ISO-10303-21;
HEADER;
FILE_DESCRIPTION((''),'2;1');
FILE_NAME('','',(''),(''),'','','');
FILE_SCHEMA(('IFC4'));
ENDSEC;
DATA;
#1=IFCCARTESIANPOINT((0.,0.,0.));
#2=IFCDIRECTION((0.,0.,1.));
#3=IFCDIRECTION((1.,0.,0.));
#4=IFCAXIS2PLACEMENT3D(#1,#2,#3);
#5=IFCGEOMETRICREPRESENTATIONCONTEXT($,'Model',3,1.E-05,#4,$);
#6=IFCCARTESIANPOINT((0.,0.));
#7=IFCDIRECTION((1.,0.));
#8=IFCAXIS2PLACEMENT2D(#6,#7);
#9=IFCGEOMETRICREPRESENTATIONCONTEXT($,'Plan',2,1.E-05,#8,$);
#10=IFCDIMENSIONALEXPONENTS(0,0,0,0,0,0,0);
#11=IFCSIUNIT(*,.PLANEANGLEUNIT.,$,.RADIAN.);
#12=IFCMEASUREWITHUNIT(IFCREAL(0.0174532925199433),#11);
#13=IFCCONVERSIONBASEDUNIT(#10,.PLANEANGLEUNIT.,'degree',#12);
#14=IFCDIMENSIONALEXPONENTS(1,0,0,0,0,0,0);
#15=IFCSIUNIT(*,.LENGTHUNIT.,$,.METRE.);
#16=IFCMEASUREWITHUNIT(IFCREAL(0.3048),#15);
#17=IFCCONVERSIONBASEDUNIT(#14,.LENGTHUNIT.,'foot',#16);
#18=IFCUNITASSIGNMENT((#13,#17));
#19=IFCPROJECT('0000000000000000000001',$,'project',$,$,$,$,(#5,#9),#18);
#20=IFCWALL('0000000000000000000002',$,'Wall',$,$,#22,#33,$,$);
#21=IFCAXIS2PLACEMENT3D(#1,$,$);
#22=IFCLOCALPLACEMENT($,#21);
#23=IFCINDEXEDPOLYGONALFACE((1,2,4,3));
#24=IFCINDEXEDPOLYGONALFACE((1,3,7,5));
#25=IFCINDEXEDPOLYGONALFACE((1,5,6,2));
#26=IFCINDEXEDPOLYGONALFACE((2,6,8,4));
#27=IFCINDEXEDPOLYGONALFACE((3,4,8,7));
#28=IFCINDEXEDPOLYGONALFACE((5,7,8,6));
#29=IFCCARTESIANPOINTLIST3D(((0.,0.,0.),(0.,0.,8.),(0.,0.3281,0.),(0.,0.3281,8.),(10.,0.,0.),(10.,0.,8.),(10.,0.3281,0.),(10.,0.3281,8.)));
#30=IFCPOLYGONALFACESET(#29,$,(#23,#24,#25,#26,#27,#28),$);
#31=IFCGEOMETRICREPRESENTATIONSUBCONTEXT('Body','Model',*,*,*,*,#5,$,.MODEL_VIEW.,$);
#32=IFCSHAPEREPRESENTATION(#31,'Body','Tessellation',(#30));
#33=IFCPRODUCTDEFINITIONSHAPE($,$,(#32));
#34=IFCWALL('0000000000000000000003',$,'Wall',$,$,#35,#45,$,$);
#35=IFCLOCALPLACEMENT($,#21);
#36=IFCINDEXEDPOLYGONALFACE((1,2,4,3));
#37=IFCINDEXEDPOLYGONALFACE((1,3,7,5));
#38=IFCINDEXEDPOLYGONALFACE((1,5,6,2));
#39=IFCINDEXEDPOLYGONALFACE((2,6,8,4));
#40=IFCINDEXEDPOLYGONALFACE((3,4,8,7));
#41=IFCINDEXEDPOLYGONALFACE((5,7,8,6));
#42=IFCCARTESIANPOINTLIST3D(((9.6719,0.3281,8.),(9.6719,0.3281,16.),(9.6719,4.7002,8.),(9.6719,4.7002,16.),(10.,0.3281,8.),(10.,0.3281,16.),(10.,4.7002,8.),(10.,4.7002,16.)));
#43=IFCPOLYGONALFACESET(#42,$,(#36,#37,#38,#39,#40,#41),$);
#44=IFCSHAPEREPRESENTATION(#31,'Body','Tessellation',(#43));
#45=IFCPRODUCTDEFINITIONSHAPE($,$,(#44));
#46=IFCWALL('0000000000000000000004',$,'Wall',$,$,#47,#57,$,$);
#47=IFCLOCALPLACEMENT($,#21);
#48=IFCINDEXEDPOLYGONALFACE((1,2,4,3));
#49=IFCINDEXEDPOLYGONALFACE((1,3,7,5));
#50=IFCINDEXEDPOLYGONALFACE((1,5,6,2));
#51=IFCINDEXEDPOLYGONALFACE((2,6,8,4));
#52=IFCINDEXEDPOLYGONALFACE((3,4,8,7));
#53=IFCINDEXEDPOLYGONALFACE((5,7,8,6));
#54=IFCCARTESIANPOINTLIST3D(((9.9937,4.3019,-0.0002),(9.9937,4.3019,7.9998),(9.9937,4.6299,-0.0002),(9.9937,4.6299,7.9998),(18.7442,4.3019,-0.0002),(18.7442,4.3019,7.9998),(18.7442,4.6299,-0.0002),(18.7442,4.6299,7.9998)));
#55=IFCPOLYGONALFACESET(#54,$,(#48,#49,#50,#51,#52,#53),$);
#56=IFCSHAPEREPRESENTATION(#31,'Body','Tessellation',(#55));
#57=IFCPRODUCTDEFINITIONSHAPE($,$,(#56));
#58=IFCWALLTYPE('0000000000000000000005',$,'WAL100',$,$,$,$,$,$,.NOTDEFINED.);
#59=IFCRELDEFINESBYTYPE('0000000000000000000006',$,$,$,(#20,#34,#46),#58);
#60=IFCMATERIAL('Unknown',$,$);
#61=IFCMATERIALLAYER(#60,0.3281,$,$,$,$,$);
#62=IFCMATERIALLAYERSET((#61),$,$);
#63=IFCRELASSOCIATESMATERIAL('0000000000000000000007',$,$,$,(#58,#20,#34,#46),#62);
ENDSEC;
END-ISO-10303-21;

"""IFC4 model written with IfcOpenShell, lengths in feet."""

from ifc_helpers import new_model, entity, si_unit, converted_unit, frame, origin_with_axes, origin_2d_with_axis, place, context, subcontext, project, indexed_curve, outline, extrude, material, layer, layer_set, layer_usage, type_object, element, save


model = new_model("IFC4")

# Units and contexts
model_context = context("Model", 3, precision=1e-05, world=origin_with_axes())
plan_context = context("Plan", 2, precision=1e-05, world=origin_2d_with_axis())
body_context = subcontext(model_context, "Body", "Model", "MODEL_VIEW")
ifc_project = project(units=[converted_unit("PLANEANGLEUNIT", "degree", entity("IfcReal", 0.0174532925199433), si_unit("PLANEANGLEUNIT", "RADIAN"), dimensions=[0, 0, 0, 0, 0, 0, 0]), converted_unit("LENGTHUNIT", "foot", entity("IfcReal", 0.3048), si_unit("LENGTHUNIT", "METRE"), dimensions=[1, 0, 0, 0, 0, 0, 0])], contexts=[model_context, plan_context])

# Walls
ifc_material = material(Name="Unknown")
ifc_layer = layer(ifc_material, 0.3281)
ifc_layer_set = layer_set([ifc_layer])
ifc_layer_usage_1 = layer_usage(ifc_layer_set, "AXIS2", "POSITIVE", 0.0)
wall_type = type_object("IfcWallType", Name="WAL100", PredefinedType="NOTDEFINED", material=ifc_layer_set)
wall_1_placement = place(None, origin_with_axes())
element("IfcWall", 1, at=wall_1_placement, type_object=wall_type, material=ifc_layer_usage_1, Name="Wall", context=body_context, shape_type="SweptSolid", body=[
    extrude(outline(indexed_curve([(0.0, 0.0), (0.0, 0.3281), (10.0, 0.3281), (10.0, 0.0), (0.0, 0.0)], self_intersect=False)), origin_with_axes(), (0.0, 0.0, 1.0), 8.0),
])
ifc_layer_usage_2 = layer_usage(ifc_layer_set, "AXIS2", "POSITIVE", 0.0)
wall_2_placement = place(None, frame((10.0, 0.3281, 8.0), z_axis=(0.0, 0.0, 1.0), x_axis=(0.0, 1.0, 0.0)))
element("IfcWall", 2, at=wall_2_placement, type_object=wall_type, material=ifc_layer_usage_2, Name="Wall", context=body_context, shape_type="SweptSolid", body=[
    extrude(outline(indexed_curve([(0.0, 0.0), (0.0, 0.3281), (4.3721, 0.3281), (4.3721, 0.0), (0.0, 0.0)], self_intersect=False)), origin_with_axes(), (0.0, 0.0, 1.0), 8.0),
])
ifc_layer_usage_3 = layer_usage(ifc_layer_set, "AXIS2", "POSITIVE", 0.0)
wall_3_placement = place(None, frame((9.9937, 4.3019, -0.0002), z_axis=(0.0, 0.0, 1.0), x_axis=(1.0, 0.0, 0.0)))
element("IfcWall", 3, at=wall_3_placement, type_object=wall_type, material=ifc_layer_usage_3, Name="Wall", context=body_context, shape_type="SweptSolid", body=[
    extrude(outline(indexed_curve([(0.0, 0.0), (0.0, 0.3281), (8.7505, 0.3281), (8.7505, 0.0), (0.0, 0.0)], self_intersect=False)), origin_with_axes(), (0.0, 0.0, 1.0), 8.0),
])

save(model, "model.ifc")
